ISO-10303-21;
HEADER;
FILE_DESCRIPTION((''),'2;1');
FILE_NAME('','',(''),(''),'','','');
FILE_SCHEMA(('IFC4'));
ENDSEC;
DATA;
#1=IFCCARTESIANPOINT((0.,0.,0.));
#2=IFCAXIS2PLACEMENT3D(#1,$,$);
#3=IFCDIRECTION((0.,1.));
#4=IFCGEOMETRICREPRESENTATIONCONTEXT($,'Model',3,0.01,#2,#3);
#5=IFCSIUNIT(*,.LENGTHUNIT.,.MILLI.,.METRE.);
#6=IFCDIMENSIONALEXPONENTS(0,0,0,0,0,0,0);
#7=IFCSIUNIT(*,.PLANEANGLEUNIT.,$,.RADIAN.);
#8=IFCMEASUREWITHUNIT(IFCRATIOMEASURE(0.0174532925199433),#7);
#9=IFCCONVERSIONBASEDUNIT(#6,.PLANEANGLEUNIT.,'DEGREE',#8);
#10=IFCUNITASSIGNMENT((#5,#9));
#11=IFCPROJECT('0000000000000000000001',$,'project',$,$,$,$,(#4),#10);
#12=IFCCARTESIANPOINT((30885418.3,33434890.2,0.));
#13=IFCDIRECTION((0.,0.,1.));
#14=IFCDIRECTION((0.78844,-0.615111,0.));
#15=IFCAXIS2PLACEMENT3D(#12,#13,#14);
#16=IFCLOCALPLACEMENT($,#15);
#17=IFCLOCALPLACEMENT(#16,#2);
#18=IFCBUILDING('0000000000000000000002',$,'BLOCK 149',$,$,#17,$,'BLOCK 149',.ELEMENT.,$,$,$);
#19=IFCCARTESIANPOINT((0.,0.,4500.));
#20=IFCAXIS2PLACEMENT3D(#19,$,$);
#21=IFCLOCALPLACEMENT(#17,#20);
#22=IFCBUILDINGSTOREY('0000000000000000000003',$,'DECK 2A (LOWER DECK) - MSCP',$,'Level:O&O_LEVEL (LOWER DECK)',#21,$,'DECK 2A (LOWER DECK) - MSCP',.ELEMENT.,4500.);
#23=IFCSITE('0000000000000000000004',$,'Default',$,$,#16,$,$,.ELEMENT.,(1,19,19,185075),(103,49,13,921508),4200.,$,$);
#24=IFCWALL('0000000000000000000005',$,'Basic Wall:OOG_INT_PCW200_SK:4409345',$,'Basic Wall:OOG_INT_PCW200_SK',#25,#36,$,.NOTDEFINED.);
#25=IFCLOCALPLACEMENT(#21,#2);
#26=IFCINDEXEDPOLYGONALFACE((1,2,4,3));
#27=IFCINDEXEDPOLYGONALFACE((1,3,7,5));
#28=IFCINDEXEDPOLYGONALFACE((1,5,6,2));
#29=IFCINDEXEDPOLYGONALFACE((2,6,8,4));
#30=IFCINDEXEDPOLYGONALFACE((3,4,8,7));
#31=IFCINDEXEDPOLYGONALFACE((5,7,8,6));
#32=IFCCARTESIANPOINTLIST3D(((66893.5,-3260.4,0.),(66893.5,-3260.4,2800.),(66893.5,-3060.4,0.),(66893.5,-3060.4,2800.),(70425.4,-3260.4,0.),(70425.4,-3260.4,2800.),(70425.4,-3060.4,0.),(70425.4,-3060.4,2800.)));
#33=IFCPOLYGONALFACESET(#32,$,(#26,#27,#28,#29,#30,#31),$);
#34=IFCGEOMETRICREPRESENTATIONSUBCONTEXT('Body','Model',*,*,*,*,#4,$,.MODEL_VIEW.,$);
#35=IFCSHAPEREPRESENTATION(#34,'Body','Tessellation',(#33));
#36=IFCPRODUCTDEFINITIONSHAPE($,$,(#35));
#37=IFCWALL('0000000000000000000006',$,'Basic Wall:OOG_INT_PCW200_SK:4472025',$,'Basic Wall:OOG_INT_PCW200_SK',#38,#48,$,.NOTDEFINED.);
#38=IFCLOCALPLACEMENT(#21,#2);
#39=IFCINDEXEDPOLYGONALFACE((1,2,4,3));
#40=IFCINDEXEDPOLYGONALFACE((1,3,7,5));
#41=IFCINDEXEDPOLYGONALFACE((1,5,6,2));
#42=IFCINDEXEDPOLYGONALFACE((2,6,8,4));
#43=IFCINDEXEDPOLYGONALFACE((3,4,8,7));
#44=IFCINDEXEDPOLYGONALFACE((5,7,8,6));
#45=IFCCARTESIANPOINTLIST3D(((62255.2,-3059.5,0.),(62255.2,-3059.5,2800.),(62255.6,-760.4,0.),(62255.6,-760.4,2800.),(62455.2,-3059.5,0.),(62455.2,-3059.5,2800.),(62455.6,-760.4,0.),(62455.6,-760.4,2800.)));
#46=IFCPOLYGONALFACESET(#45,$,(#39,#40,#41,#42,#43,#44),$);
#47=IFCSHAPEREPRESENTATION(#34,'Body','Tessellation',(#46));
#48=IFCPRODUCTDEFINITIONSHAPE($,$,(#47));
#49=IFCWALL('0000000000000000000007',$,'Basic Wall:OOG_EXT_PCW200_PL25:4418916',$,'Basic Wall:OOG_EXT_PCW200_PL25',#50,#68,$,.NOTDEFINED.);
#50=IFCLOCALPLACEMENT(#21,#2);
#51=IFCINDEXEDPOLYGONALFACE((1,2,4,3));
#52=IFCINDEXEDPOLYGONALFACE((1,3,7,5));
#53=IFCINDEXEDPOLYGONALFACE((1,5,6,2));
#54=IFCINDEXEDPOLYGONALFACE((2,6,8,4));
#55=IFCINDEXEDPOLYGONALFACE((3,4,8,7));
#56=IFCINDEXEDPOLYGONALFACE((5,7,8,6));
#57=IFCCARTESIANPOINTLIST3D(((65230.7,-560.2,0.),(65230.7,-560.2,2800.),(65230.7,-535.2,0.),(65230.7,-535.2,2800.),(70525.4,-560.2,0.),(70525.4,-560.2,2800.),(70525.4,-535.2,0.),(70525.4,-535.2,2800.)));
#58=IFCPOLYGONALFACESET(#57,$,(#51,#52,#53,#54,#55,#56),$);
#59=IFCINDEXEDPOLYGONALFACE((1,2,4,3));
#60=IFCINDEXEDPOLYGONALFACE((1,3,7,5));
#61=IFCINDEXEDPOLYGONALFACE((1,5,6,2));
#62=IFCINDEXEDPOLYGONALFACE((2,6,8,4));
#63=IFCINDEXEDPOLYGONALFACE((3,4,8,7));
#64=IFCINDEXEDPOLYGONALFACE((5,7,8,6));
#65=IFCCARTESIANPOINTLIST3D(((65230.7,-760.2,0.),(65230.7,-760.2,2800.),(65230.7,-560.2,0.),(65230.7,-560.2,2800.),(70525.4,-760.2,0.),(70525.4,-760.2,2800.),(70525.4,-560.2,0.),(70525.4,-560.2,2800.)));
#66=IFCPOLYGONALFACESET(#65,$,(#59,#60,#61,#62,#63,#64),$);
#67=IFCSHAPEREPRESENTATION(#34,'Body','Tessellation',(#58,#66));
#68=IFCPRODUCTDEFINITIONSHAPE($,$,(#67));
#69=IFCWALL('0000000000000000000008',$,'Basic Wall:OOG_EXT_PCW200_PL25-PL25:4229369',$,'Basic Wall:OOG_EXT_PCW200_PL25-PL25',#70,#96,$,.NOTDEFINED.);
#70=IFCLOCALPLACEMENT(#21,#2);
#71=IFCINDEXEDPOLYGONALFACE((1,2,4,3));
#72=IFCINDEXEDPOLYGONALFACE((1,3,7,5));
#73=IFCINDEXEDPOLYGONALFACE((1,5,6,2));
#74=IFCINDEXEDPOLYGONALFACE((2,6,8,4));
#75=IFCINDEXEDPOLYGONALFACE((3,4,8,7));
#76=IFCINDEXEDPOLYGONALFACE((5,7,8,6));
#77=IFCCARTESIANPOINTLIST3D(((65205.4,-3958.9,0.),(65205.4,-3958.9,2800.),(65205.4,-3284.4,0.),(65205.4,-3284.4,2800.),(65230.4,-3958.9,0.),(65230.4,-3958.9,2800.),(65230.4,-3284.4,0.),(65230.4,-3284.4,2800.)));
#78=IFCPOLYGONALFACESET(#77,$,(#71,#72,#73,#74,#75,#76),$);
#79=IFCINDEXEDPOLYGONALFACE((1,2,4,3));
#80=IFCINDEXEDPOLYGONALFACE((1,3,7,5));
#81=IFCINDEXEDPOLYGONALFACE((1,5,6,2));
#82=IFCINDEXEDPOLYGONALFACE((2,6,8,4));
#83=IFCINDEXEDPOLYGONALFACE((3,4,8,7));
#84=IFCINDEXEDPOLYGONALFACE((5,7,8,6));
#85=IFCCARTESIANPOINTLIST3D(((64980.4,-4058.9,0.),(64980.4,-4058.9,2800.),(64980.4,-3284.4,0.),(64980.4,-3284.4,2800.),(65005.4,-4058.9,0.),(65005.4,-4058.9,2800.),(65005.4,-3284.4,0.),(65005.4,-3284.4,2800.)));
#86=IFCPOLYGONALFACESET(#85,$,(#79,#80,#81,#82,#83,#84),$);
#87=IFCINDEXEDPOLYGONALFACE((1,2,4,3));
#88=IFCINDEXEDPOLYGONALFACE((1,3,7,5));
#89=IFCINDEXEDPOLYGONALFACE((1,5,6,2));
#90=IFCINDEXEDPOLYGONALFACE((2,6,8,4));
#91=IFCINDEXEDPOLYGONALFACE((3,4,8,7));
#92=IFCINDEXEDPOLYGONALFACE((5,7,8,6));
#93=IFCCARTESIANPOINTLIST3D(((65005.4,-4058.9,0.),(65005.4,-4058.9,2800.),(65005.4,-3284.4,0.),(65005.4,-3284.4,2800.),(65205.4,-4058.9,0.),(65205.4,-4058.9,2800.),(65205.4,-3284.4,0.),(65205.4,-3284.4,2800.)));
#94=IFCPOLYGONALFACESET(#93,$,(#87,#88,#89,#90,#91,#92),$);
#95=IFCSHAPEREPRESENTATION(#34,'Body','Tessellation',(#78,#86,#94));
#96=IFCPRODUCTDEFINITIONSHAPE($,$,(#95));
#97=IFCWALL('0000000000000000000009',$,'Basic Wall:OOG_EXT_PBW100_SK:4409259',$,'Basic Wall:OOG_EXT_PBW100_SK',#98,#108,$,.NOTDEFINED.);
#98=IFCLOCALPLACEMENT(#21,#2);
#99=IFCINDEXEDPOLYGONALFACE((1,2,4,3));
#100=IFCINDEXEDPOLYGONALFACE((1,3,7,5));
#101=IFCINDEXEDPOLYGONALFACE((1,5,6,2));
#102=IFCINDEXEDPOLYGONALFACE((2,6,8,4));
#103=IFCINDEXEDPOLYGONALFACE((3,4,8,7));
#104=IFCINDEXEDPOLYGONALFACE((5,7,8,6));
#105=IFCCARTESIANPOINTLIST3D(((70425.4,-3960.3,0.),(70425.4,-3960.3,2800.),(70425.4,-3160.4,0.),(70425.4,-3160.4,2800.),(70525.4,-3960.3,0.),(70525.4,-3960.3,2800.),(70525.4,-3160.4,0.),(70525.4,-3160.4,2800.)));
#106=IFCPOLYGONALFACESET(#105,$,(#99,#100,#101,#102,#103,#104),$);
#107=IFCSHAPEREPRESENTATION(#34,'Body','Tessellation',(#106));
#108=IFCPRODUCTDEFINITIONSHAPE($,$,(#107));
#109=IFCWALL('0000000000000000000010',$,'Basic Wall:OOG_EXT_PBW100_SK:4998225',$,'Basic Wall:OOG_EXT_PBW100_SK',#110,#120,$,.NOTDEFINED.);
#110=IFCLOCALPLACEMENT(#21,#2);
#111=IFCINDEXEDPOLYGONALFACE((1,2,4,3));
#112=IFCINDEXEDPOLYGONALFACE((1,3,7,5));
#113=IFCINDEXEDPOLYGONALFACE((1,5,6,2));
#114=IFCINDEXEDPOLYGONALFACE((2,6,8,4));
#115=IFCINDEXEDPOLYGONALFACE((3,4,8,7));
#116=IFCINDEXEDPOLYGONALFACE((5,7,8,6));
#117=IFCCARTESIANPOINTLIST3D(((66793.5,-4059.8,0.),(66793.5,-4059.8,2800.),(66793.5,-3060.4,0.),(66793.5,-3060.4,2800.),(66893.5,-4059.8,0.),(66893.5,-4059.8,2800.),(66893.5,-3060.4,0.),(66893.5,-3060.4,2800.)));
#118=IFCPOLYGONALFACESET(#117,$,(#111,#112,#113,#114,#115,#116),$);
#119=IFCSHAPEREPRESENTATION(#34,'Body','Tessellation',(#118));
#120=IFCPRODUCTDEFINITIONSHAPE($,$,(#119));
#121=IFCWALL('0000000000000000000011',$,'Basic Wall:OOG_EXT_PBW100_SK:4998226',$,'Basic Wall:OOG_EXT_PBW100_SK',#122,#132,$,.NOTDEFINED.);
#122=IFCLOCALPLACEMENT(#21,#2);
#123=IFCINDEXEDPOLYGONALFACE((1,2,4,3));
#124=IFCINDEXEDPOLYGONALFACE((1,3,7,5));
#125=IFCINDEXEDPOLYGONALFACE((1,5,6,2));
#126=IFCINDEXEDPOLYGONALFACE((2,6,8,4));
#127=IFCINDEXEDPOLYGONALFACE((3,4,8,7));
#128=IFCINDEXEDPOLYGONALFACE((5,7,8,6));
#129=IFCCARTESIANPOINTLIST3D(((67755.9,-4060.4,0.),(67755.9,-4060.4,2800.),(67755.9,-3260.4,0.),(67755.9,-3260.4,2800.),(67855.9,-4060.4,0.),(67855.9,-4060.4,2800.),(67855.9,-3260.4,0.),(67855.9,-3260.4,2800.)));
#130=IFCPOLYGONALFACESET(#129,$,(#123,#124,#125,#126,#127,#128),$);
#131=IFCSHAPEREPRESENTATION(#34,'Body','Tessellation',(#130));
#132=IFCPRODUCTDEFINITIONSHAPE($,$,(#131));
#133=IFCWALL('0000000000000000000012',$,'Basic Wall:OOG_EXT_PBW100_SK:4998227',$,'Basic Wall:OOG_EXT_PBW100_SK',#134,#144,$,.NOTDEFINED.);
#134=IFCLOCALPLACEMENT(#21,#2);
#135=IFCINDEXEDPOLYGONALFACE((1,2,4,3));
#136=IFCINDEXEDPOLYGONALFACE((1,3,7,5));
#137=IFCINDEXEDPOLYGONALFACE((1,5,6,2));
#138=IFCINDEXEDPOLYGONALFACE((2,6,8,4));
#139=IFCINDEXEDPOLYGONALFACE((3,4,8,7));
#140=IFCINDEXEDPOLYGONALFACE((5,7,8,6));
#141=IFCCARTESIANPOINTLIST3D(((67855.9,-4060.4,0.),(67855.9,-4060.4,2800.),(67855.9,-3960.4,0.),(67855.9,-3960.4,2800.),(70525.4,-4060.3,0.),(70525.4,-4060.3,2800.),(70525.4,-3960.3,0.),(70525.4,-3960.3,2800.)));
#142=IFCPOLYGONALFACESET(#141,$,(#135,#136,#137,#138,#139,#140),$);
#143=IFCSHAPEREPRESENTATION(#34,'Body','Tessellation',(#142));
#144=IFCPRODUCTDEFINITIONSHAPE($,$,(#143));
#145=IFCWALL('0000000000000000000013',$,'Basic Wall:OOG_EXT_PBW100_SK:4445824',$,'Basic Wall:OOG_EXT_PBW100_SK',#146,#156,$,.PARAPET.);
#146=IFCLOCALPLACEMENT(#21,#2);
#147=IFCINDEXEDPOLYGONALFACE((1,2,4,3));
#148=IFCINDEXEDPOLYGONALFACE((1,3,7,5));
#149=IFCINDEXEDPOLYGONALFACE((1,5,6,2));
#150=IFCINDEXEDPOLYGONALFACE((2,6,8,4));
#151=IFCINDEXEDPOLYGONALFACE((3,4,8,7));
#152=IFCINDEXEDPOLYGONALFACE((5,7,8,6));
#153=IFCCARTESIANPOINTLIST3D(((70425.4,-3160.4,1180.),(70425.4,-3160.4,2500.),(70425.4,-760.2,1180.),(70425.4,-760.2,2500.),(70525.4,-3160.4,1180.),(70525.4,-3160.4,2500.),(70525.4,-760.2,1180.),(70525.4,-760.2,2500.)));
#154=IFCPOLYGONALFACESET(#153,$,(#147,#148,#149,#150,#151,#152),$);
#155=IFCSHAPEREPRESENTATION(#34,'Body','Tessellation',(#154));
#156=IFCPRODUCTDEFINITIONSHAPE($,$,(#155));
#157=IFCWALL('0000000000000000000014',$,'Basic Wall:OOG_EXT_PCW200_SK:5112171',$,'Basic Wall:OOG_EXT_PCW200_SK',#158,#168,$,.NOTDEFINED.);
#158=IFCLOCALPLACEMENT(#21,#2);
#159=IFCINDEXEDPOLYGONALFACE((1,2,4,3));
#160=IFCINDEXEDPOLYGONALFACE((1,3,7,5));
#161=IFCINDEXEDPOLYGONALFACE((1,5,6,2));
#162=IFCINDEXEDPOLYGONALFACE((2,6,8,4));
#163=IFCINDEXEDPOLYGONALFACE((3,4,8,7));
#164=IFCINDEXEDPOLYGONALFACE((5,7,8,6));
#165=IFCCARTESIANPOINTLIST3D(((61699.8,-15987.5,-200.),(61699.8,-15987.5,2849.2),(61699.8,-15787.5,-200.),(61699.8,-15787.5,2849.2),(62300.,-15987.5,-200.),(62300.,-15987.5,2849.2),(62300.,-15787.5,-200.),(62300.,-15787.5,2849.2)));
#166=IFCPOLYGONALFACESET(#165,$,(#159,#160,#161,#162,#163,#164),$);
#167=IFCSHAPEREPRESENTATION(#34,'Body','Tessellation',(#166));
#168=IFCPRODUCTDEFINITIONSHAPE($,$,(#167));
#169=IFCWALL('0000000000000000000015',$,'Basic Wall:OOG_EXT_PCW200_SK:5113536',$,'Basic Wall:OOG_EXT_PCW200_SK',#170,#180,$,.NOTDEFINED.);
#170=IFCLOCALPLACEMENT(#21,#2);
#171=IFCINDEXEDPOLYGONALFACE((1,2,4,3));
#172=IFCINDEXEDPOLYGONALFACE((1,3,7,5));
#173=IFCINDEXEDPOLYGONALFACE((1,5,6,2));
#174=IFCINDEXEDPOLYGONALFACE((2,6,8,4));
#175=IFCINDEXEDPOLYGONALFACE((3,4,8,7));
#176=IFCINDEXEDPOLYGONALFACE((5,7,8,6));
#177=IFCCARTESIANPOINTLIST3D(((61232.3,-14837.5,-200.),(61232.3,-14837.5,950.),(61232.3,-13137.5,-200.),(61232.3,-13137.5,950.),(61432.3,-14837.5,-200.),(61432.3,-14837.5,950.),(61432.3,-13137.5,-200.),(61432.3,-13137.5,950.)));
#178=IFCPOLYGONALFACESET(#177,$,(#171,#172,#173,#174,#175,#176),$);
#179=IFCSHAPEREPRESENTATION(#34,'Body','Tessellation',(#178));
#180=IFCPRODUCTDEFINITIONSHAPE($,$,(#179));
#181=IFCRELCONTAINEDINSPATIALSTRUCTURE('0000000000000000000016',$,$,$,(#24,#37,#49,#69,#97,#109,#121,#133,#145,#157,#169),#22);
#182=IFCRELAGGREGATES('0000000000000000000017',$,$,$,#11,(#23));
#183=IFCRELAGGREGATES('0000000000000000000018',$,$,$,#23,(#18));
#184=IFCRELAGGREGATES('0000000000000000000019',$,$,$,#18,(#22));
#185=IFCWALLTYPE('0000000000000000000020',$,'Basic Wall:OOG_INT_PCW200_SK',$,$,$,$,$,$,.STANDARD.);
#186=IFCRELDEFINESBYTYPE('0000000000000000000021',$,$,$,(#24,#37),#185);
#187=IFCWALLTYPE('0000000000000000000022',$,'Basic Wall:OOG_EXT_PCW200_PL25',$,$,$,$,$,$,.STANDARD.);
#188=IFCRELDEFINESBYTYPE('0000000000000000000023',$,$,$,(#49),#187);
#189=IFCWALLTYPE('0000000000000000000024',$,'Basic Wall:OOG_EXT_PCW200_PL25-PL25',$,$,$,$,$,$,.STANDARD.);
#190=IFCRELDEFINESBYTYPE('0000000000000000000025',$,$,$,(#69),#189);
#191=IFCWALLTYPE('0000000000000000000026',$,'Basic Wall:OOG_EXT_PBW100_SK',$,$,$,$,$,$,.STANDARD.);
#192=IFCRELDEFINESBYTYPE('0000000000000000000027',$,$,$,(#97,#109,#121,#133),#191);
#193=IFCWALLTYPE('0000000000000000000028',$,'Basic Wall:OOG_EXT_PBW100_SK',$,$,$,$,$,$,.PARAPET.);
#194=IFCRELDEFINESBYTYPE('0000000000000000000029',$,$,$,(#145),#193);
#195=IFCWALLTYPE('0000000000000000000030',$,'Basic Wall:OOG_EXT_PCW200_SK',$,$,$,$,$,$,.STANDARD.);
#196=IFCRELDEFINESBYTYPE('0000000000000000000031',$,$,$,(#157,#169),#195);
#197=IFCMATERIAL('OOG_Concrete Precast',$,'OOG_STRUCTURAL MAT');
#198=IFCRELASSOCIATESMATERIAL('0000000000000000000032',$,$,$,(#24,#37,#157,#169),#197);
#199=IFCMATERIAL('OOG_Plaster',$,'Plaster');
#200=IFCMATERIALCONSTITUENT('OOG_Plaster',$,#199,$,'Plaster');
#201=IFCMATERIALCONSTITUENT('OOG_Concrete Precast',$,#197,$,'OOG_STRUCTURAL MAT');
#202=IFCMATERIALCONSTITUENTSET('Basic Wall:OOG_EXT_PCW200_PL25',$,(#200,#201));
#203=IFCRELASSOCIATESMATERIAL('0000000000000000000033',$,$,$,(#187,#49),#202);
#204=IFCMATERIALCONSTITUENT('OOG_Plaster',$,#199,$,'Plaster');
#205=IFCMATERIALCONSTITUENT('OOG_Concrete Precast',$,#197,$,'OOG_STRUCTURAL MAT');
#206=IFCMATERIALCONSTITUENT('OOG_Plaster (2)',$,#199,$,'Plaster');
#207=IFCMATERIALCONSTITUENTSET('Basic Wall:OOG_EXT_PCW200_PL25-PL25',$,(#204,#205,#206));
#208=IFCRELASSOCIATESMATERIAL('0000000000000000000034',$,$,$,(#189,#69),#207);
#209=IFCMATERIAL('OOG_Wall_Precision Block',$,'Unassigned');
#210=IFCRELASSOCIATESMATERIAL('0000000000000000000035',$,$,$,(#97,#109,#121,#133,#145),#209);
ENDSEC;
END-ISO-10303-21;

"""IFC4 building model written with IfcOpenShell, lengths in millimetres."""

from ifc_helpers import new_model, entity, si_unit, converted_unit, direction, frame, origin, place, context, subcontext, project, spatial, indexed_curve, outline, extrude, material, constituent, constituent_set, type_object, element, save


model = new_model("IFC4")

# Units and contexts
model_context = context("Model", 3, precision=0.01, world=origin(), true_north=direction((0.0, 1.0)))
body_context = subcontext(model_context, "Body", "Model", "MODEL_VIEW")
ifc_project = project(units=[si_unit("LENGTHUNIT", "METRE", prefix="MILLI"), converted_unit("PLANEANGLEUNIT", "DEGREE", entity("IfcRatioMeasure", 0.0174532925199433), si_unit("PLANEANGLEUNIT", "RADIAN"), dimensions=[0, 0, 0, 0, 0, 0, 0])], contexts=[model_context])

# Site, building, storey
site_placement = place(None, frame((30885418.3, 33434890.2, 0.0), z_axis=(0.0, 0.0, 1.0), x_axis=(0.78844, -0.615111, 0.0)))
site = spatial("IfcSite", under=ifc_project, at=site_placement, Name="Default", CompositionType="ELEMENT", RefLatitude=(1, 19, 19, 185075), RefLongitude=(103, 49, 13, 921508), RefElevation=4200.0)
building_placement = place(site_placement, origin())
building = spatial("IfcBuilding", under=site, at=building_placement, Name="BLOCK 149", LongName="BLOCK 149", CompositionType="ELEMENT")
storey_placement = place(building_placement, frame((0.0, 0.0, 4500.0)))
storey = spatial("IfcBuildingStorey", under=building, at=storey_placement, Name="DECK 2A (LOWER DECK) - MSCP", ObjectType="Level:O&O_LEVEL (LOWER DECK)", LongName="DECK 2A (LOWER DECK) - MSCP", CompositionType="ELEMENT", Elevation=4500.0)

# Walls
ifc_material_1 = material(Name="OOG_Concrete Precast", Category="OOG_STRUCTURAL MAT")
wall_type_1 = type_object("IfcWallType", Name="Basic Wall:OOG_INT_PCW200_SK", PredefinedType="STANDARD")
wall_1_placement = place(storey_placement, frame((70425.4, -3160.4, 0.0), z_axis=(0.0, 0.0, 1.0), x_axis=(-1.0, 0.0, 0.0)))
element("IfcWall", 1, at=wall_1_placement, inside=storey, type_object=wall_type_1, material=ifc_material_1, Name="Basic Wall:OOG_INT_PCW200_SK:4409345", ObjectType="Basic Wall:OOG_INT_PCW200_SK", PredefinedType="NOTDEFINED", context=body_context, shape_type="SweptSolid", body=[
    extrude(outline(indexed_curve([(3531.9, 100.0), (0.0, 100.0), (0.0, -100.0), (3531.9, -100.0), (3531.9, 100.0)], self_intersect=False)), origin(), (0.0, 0.0, 1.0), 2800.0),
])
wall_2_placement = place(storey_placement, frame((62355.6, -760.4, 0.0), z_axis=(0.0, 0.0, 1.0), x_axis=(-0.000154, -1.0, 0.0)))
element("IfcWall", 2, at=wall_2_placement, inside=storey, type_object=wall_type_1, material=ifc_material_1, Name="Basic Wall:OOG_INT_PCW200_SK:4472025", ObjectType="Basic Wall:OOG_INT_PCW200_SK", PredefinedType="NOTDEFINED", context=body_context, shape_type="SweptSolid", body=[
    extrude(outline(indexed_curve([(2299.1, -100.0), (2299.1, 100.0), (0.0, 100.0), (0.0, -100.0), (2299.1, -100.0)], self_intersect=False)), origin(), (0.0, 0.0, 1.0), 2800.0),
])
ifc_material_2 = material(Name="OOG_Plaster", Category="Plaster")
ifc_constituent_1 = constituent(ifc_material_2, Name="OOG_Plaster", Category="Plaster")
ifc_constituent_2 = constituent(ifc_material_1, Name="OOG_Concrete Precast", Category="OOG_STRUCTURAL MAT")
ifc_constituent_set_1 = constituent_set(constituents=[ifc_constituent_1, ifc_constituent_2], Name="Basic Wall:OOG_EXT_PCW200_PL25")
wall_type_2 = type_object("IfcWallType", Name="Basic Wall:OOG_EXT_PCW200_PL25", PredefinedType="STANDARD", material=ifc_constituent_set_1)

# Walls
wall_3_placement = place(storey_placement, frame((70525.4, -647.7, 0.0), z_axis=(0.0, 0.0, 1.0), x_axis=(-1.0, 0.0, 0.0)))
element("IfcWall", 3, at=wall_3_placement, inside=storey, type_object=wall_type_2, material=ifc_constituent_set_1, Name="Basic Wall:OOG_EXT_PCW200_PL25:4418916", ObjectType="Basic Wall:OOG_EXT_PCW200_PL25", PredefinedType="NOTDEFINED", context=body_context, shape_type="SweptSolid", body=[
    extrude(outline(indexed_curve([(-12.5, -2647.3), (12.5, -2647.3), (12.5, 2647.3), (-12.5, 2647.3), (-12.5, -2647.3)], self_intersect=False)), frame((2647.3, -100.0, 0.0), z_axis=(0.0, 0.0, 1.0), x_axis=(0.0, 1.0, 0.0)), (0.0, 0.0, 1.0), 2800.0),
    extrude(outline(indexed_curve([(-100.0, -2647.3), (100.0, -2647.3), (100.0, 2647.3), (-100.0, 2647.3), (-100.0, -2647.3)], self_intersect=False)), frame((2647.3, 12.5, 0.0), z_axis=(0.0, 0.0, 1.0), x_axis=(0.0, 1.0, 0.0)), (0.0, 0.0, 1.0), 2800.0),
])
ifc_constituent_3 = constituent(ifc_material_2, Name="OOG_Plaster", Category="Plaster")
ifc_constituent_4 = constituent(ifc_material_1, Name="OOG_Concrete Precast", Category="OOG_STRUCTURAL MAT")
ifc_constituent_5 = constituent(ifc_material_2, Name="OOG_Plaster (2)", Category="Plaster")
ifc_constituent_set_2 = constituent_set(constituents=[ifc_constituent_3, ifc_constituent_4, ifc_constituent_5], Name="Basic Wall:OOG_EXT_PCW200_PL25-PL25")
wall_type_3 = type_object("IfcWallType", Name="Basic Wall:OOG_EXT_PCW200_PL25-PL25", PredefinedType="STANDARD", material=ifc_constituent_set_2)
wall_4_placement = place(storey_placement, frame((65105.4, -4058.9, 0.0), z_axis=(0.0, 0.0, 1.0), x_axis=(0.0, 1.0, 0.0)))
element("IfcWall", 4, at=wall_4_placement, inside=storey, type_object=wall_type_3, material=ifc_constituent_set_2, Name="Basic Wall:OOG_EXT_PCW200_PL25-PL25:4229369", ObjectType="Basic Wall:OOG_EXT_PCW200_PL25-PL25", PredefinedType="NOTDEFINED", context=body_context, shape_type="SweptSolid", body=[
    extrude(outline(indexed_curve([(-337.3, -12.5), (337.3, -12.5), (337.3, 12.5), (-337.3, 12.5), (-337.3, -12.5)], self_intersect=False)), frame((437.3, -112.5, 0.0)), (0.0, 0.0, 1.0), 2800.0),
    extrude(outline(indexed_curve([(-12.5, -387.3), (12.5, -387.3), (12.5, 387.3), (-12.5, 387.3), (-12.5, -387.3)], self_intersect=False)), frame((387.3, 112.5, 0.0), z_axis=(0.0, 0.0, 1.0), x_axis=(0.0, -1.0, 0.0)), (0.0, 0.0, 1.0), 2800.0),
    extrude(outline(indexed_curve([(-387.3, -100.0), (387.3, -100.0), (387.3, 100.0), (-387.3, 100.0), (-387.3, -100.0)], self_intersect=False)), frame((387.3, 0.0, 0.0)), (0.0, 0.0, 1.0), 2800.0),
])
ifc_material_3 = material(Name="OOG_Wall_Precision Block", Category="Unassigned")
wall_type_4 = type_object("IfcWallType", Name="Basic Wall:OOG_EXT_PBW100_SK", PredefinedType="STANDARD")
wall_5_placement = place(storey_placement, frame((70475.4, -3160.4, 0.0), z_axis=(0.0, 0.0, 1.0), x_axis=(0.0, -1.0, 0.0)))
element("IfcWall", 5, at=wall_5_placement, inside=storey, type_object=wall_type_4, material=ifc_material_3, Name="Basic Wall:OOG_EXT_PBW100_SK:4409259", ObjectType="Basic Wall:OOG_EXT_PBW100_SK", PredefinedType="NOTDEFINED", context=body_context, shape_type="SweptSolid", body=[
    extrude(outline(indexed_curve([(799.9, 50.0), (0.0, 50.0), (0.0, -50.0), (799.9, -50.0), (799.9, 50.0)], self_intersect=False)), origin(), (0.0, 0.0, 1.0), 2800.0),
])
wall_6_placement = place(storey_placement, frame((66843.5, -3060.4, 0.0), z_axis=(0.0, 0.0, 1.0), x_axis=(0.0, -1.0, 0.0)))
element("IfcWall", 6, at=wall_6_placement, inside=storey, type_object=wall_type_4, material=ifc_material_3, Name="Basic Wall:OOG_EXT_PBW100_SK:4998225", ObjectType="Basic Wall:OOG_EXT_PBW100_SK", PredefinedType="NOTDEFINED", context=body_context, shape_type="SweptSolid", body=[
    extrude(outline(indexed_curve([(999.4, 50.0), (0.0, 50.0), (0.0, -50.0), (999.4, -50.0), (999.4, 50.0)], self_intersect=False)), origin(), (0.0, 0.0, 1.0), 2800.0),
])
wall_7_placement = place(storey_placement, frame((67805.9, -4060.4, 0.0), z_axis=(0.0, 0.0, 1.0), x_axis=(-0.000034, 1.0, 0.0)))
element("IfcWall", 7, at=wall_7_placement, inside=storey, type_object=wall_type_4, material=ifc_material_3, Name="Basic Wall:OOG_EXT_PBW100_SK:4998226", ObjectType="Basic Wall:OOG_EXT_PBW100_SK", PredefinedType="NOTDEFINED", context=body_context, shape_type="SweptSolid", body=[
    extrude(outline(indexed_curve([(800.0, 50.0), (0.0, 50.0), (0.0, -50.0), (800.0, -50.0), (800.0, 50.0)], self_intersect=False)), origin(), (0.0, 0.0, 1.0), 2800.0),
])
wall_8_placement = place(storey_placement, frame((70525.4, -4010.3, 0.0), z_axis=(0.0, 0.0, 1.0), x_axis=(-1.0, -0.000034, 0.0)))
element("IfcWall", 8, at=wall_8_placement, inside=storey, type_object=wall_type_4, material=ifc_material_3, Name="Basic Wall:OOG_EXT_PBW100_SK:4998227", ObjectType="Basic Wall:OOG_EXT_PBW100_SK", PredefinedType="NOTDEFINED", context=body_context, shape_type="SweptSolid", body=[
    extrude(outline(indexed_curve([(2669.5, 50.0), (0.0, 50.0), (0.0, -50.0), (2669.5, -50.0), (2669.5, 50.0)], self_intersect=False)), origin(), (0.0, 0.0, 1.0), 2800.0),
])
wall_type_5 = type_object("IfcWallType", Name="Basic Wall:OOG_EXT_PBW100_SK", PredefinedType="PARAPET")
wall_9_placement = place(storey_placement, frame((70475.4, -760.2, 1180.0), z_axis=(0.0, 0.0, 1.0), x_axis=(0.0, -1.0, 0.0)))
element("IfcWall", 9, at=wall_9_placement, inside=storey, type_object=wall_type_5, material=ifc_material_3, Name="Basic Wall:OOG_EXT_PBW100_SK:4445824", ObjectType="Basic Wall:OOG_EXT_PBW100_SK", PredefinedType="PARAPET", context=body_context, shape_type="SweptSolid", body=[
    extrude(outline(indexed_curve([(2400.2, 50.0), (0.0, 50.0), (0.0, -50.0), (2400.2, -50.0), (2400.2, 50.0)], self_intersect=False)), origin(), (0.0, 0.0, 1.0), 1320.0),
])
wall_type_6 = type_object("IfcWallType", Name="Basic Wall:OOG_EXT_PCW200_SK", PredefinedType="STANDARD")
wall_10_placement = place(storey_placement, frame((62300.0, -15887.5, -200.0), z_axis=(0.0, 0.0, 1.0), x_axis=(-1.0, 0.0, 0.0)))
element("IfcWall", 10, at=wall_10_placement, inside=storey, type_object=wall_type_6, material=ifc_material_1, Name="Basic Wall:OOG_EXT_PCW200_SK:5112171", ObjectType="Basic Wall:OOG_EXT_PCW200_SK", PredefinedType="NOTDEFINED", context=body_context, shape_type="SweptSolid", body=[
    extrude(outline(indexed_curve([(600.2, 100.0), (0.0, 100.0), (0.0, -100.0), (600.2, -100.0), (600.2, 100.0)], self_intersect=False)), origin(), (0.0, 0.0, 1.0), 3049.2),
])
wall_11_placement = place(storey_placement, frame((61332.3, -13137.5, -200.0), z_axis=(0.0, 0.0, 1.0), x_axis=(0.0, -1.0, 0.0)))
element("IfcWall", 11, at=wall_11_placement, inside=storey, type_object=wall_type_6, material=ifc_material_1, Name="Basic Wall:OOG_EXT_PCW200_SK:5113536", ObjectType="Basic Wall:OOG_EXT_PCW200_SK", PredefinedType="NOTDEFINED", context=body_context, shape_type="SweptSolid", body=[
    extrude(outline(indexed_curve([(1700.0, 100.0), (0.0, 100.0), (0.0, -100.0), (1700.0, -100.0), (1700.0, 100.0)], self_intersect=False)), origin(), (0.0, 0.0, 1.0), 1150.0),
])

save(model, "model.ifc")
